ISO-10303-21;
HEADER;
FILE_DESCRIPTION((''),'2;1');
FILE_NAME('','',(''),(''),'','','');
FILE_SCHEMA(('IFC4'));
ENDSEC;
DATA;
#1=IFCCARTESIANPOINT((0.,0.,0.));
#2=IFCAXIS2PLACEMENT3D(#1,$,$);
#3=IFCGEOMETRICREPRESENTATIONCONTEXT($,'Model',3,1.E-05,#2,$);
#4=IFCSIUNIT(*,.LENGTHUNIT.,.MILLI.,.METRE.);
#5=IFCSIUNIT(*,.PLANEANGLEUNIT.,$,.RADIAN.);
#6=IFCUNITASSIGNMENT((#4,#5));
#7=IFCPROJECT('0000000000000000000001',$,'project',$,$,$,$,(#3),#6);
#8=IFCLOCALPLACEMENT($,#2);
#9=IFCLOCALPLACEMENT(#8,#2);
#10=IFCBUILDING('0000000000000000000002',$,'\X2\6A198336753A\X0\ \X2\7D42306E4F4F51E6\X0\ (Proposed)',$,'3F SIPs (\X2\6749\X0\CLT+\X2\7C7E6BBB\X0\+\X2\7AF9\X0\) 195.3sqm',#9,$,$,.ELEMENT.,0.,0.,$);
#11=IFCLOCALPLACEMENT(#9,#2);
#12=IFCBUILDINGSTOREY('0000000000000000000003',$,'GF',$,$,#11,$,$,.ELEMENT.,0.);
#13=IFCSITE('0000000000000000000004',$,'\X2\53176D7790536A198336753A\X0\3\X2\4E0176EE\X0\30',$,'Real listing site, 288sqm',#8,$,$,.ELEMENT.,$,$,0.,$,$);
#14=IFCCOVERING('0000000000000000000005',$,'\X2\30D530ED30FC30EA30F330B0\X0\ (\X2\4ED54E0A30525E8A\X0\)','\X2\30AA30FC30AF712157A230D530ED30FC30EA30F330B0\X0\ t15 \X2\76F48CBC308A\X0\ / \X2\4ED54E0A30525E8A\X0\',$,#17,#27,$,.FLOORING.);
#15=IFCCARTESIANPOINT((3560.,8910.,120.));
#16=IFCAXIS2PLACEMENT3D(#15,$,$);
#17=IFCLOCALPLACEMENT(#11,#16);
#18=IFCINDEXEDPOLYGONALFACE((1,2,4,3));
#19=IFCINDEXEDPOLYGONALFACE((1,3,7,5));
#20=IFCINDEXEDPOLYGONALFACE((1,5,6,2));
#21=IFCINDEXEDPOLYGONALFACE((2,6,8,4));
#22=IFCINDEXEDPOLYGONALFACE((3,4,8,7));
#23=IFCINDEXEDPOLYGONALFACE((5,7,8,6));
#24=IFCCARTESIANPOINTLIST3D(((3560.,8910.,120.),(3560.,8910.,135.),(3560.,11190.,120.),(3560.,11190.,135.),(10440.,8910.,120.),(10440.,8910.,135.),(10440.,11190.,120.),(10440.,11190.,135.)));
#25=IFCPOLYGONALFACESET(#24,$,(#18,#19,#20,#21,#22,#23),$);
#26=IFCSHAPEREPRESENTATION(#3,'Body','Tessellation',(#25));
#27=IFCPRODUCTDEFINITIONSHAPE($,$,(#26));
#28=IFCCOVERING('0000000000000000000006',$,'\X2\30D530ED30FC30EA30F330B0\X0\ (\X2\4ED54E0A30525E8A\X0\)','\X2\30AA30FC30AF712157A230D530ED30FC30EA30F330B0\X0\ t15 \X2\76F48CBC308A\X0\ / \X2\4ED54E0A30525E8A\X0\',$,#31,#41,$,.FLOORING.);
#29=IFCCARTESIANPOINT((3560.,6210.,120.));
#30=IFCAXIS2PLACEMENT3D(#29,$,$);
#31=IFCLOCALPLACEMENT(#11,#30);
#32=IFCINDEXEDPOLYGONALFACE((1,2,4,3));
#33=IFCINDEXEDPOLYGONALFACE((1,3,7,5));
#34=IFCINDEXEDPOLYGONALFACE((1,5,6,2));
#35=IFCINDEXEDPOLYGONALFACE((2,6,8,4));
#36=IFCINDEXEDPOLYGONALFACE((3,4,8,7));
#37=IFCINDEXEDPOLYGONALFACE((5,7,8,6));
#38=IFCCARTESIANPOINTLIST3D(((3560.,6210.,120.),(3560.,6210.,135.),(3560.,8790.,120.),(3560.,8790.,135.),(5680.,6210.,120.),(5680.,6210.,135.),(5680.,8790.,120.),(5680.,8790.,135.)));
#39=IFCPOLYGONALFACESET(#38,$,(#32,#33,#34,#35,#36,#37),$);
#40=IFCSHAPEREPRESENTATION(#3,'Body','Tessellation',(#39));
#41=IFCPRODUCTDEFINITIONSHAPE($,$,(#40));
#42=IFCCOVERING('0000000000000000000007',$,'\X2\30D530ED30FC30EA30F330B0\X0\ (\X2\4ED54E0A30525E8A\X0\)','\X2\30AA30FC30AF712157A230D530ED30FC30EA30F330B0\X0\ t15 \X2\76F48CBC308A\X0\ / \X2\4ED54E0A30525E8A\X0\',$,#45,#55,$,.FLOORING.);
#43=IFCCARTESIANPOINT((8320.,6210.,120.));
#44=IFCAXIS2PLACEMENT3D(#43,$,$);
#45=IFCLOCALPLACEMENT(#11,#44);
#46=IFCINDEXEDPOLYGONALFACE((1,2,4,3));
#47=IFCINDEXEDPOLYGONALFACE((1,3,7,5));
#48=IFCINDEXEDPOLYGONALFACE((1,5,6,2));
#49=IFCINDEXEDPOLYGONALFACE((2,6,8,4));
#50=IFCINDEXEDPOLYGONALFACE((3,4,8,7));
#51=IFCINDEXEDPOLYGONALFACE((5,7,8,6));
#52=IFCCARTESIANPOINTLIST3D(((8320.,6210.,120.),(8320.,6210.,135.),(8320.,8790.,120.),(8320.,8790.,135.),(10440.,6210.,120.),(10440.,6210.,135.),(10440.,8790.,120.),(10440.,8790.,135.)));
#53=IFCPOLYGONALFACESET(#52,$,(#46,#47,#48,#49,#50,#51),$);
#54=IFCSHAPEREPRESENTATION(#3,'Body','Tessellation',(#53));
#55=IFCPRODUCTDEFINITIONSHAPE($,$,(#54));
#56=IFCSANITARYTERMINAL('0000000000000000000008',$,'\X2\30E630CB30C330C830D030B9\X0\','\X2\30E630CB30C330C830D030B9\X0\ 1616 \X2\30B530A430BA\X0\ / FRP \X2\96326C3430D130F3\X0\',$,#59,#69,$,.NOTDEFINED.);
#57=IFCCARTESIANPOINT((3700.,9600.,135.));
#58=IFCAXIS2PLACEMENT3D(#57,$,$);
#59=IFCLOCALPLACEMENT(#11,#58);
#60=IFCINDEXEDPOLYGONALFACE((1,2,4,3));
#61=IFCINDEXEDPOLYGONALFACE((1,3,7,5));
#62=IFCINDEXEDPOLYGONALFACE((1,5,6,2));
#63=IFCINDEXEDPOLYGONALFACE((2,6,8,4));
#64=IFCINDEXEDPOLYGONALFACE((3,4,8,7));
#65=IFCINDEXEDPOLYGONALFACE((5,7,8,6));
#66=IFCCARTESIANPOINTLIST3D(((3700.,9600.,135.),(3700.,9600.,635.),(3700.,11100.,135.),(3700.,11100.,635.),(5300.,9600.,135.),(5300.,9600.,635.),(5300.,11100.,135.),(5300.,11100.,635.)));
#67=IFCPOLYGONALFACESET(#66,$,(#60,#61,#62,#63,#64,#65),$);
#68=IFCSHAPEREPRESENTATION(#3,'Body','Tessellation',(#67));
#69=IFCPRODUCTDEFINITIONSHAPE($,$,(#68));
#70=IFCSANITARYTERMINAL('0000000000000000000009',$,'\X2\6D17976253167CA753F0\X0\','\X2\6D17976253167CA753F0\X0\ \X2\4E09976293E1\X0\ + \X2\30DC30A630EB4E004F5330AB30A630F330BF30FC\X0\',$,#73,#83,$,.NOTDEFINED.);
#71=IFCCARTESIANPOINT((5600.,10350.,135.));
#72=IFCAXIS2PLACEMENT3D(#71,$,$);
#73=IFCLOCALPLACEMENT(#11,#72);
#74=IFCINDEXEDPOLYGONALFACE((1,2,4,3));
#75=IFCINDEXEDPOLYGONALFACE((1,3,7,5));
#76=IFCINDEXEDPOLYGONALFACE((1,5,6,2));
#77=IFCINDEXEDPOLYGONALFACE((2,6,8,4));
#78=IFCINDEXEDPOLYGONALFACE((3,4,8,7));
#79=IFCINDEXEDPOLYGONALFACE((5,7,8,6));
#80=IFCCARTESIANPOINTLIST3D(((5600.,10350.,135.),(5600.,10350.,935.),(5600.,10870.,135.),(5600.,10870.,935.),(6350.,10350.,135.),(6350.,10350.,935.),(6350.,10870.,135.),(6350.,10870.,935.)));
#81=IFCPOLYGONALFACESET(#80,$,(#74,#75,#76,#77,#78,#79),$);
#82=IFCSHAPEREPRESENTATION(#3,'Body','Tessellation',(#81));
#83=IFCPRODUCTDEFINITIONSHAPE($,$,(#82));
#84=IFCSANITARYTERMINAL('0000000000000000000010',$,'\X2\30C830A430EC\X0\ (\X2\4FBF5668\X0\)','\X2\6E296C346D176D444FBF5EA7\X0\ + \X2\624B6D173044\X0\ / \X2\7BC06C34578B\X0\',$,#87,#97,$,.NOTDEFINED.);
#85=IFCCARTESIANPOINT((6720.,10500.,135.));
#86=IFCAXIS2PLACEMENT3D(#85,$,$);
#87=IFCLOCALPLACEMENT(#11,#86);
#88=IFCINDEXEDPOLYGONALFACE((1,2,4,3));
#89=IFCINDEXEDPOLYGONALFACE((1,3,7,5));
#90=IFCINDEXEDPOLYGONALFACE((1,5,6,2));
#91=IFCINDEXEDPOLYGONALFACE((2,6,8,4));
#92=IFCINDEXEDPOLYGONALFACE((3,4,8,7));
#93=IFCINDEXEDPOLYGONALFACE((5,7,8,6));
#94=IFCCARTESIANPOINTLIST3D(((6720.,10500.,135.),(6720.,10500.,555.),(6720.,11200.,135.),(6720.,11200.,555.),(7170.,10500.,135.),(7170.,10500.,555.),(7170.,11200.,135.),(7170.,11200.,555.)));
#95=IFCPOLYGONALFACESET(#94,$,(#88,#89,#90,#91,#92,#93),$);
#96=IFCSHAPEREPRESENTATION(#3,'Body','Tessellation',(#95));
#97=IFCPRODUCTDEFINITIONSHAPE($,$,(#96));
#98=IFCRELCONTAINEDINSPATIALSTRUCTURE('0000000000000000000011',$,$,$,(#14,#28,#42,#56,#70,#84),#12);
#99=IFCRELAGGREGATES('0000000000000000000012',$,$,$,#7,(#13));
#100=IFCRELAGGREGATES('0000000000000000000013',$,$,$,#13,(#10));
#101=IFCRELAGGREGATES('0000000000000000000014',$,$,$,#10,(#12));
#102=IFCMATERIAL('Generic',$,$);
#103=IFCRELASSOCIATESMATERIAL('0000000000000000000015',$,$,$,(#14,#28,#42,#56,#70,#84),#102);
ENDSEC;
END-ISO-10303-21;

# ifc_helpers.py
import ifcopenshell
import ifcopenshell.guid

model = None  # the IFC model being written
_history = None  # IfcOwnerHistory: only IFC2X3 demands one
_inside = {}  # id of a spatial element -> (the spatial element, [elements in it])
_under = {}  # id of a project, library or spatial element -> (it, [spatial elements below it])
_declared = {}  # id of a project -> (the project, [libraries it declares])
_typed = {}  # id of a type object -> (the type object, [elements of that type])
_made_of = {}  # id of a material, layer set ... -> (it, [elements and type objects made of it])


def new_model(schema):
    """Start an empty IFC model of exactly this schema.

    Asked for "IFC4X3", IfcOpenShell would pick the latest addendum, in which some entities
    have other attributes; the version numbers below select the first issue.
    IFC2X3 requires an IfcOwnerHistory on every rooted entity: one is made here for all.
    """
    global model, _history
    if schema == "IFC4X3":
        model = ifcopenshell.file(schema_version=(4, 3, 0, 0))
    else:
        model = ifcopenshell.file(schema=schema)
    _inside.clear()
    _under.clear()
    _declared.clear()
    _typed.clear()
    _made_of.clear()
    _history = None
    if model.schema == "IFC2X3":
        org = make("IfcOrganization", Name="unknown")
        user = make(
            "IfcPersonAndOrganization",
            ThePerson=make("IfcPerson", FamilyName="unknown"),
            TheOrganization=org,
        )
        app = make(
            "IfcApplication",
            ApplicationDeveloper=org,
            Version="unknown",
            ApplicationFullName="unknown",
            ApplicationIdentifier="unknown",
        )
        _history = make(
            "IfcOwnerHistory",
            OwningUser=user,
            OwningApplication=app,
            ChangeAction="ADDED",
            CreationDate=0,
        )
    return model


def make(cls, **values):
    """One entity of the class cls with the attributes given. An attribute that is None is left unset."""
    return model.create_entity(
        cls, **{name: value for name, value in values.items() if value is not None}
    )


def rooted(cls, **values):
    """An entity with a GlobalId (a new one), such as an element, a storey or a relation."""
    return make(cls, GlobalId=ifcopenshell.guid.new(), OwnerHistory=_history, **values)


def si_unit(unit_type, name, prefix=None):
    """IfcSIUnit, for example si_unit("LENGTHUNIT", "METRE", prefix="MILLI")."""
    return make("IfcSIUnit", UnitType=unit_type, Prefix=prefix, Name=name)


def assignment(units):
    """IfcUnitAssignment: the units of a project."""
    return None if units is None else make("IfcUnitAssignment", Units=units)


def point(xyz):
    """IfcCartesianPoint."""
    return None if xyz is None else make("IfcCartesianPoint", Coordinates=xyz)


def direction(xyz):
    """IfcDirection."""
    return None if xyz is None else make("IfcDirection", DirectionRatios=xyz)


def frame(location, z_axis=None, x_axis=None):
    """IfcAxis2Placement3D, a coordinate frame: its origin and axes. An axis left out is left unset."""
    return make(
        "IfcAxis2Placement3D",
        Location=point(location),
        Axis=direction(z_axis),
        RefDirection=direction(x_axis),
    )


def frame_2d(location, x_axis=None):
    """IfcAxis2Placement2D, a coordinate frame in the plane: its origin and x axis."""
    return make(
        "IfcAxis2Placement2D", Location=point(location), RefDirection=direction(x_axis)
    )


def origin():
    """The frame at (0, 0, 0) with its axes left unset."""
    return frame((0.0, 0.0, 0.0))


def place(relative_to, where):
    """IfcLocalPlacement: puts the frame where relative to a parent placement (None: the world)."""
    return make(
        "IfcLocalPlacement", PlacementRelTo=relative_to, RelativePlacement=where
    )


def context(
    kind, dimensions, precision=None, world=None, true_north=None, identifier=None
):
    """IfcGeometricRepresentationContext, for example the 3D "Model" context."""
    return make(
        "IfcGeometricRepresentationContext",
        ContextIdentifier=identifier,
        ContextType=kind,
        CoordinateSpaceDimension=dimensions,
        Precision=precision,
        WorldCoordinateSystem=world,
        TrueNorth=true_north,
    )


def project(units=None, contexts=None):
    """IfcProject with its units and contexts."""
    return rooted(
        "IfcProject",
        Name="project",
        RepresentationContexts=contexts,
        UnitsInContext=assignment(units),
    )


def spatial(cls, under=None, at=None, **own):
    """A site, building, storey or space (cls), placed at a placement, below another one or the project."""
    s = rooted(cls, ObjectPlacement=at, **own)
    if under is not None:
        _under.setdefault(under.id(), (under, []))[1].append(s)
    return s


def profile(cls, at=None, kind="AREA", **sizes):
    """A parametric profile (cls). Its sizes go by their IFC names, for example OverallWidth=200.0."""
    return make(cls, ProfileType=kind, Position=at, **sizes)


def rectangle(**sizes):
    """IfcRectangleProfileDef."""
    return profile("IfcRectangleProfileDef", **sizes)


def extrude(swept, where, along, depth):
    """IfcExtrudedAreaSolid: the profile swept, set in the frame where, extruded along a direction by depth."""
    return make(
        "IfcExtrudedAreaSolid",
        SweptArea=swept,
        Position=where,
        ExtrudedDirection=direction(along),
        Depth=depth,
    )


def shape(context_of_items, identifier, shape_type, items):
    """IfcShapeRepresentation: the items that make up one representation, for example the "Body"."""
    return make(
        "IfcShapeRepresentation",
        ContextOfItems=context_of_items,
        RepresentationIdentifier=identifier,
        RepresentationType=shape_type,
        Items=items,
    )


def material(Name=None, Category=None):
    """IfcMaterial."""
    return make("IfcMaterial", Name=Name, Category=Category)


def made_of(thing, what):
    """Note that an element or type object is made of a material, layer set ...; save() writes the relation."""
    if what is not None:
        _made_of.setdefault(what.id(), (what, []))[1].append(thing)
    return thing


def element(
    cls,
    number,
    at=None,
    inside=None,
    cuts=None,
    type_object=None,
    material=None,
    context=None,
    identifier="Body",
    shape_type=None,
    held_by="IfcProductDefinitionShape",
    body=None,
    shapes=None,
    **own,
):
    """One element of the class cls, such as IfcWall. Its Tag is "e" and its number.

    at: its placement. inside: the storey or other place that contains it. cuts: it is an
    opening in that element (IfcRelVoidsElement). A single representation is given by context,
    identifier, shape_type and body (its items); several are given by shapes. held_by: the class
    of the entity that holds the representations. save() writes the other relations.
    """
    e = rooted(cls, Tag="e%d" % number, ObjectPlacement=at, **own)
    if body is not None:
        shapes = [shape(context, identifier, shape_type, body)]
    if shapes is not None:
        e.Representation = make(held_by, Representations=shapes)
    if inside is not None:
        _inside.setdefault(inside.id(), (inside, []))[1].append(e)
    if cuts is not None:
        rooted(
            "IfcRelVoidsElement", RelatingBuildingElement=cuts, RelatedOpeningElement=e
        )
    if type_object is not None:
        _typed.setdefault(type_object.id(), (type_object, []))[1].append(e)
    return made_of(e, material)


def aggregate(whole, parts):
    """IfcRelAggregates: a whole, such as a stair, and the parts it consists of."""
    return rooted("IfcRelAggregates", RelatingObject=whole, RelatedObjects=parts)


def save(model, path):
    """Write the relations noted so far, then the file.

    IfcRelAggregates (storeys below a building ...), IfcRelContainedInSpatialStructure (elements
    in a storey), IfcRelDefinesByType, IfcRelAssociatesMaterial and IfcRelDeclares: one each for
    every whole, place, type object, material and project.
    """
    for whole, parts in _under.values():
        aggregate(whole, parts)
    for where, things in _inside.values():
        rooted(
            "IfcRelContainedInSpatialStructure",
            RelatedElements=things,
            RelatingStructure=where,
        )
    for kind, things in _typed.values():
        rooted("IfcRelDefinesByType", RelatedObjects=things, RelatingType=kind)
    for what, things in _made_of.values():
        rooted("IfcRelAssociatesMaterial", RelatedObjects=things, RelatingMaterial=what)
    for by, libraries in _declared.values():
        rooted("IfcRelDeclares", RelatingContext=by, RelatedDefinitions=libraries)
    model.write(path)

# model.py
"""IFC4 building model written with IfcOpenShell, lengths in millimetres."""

from ifc_helpers import new_model, si_unit, frame, frame_2d, origin, place, context, project, spatial, rectangle, extrude, material, element, save


model = new_model("IFC4")

# Units and contexts
model_context = context("Model", 3, precision=1e-05, world=origin())
ifc_project = project(units=[si_unit("LENGTHUNIT", "METRE", prefix="MILLI"), si_unit("PLANEANGLEUNIT", "RADIAN")], contexts=[model_context])

# Site, building, storey
site_placement = place(None, origin())
site = spatial("IfcSite", under=ifc_project, at=site_placement, Name="北海道標茶町3丁目30", ObjectType="Real listing site, 288sqm", CompositionType="ELEMENT", RefElevation=0.0)
building_placement = place(site_placement, origin())
building = spatial("IfcBuilding", under=site, at=building_placement, Name="標茶町 終の住処 (Proposed)", ObjectType="3F SIPs (杉CLT+籾殻+竹) 195.3sqm", CompositionType="ELEMENT", ElevationOfRefHeight=0.0, ElevationOfTerrain=0.0)
storey_placement = place(building_placement, origin())
storey = spatial("IfcBuildingStorey", under=building, at=storey_placement, Name="GF", CompositionType="ELEMENT", Elevation=0.0)

# Coverings
ifc_material_1 = material(Name="Generic")
covering_1_placement = place(storey_placement, frame((3560.0, 8910.0, 120.0)))
element("IfcCovering", 1, at=covering_1_placement, inside=storey, material=ifc_material_1, Name="フローリング (仕上げ床)", Description="オーク無垢フローリング t15 直貼り / 仕上げ床", PredefinedType="FLOORING", context=model_context, shape_type="SweptSolid", body=[
    extrude(rectangle(XDim=6880.0, YDim=2280.0, at=frame_2d((3440.0, 1140.0))), frame((3560.0, 8910.0, 120.0)), (0.0, 0.0, 1.0), 15.0),
])
covering_2_placement = place(storey_placement, frame((3560.0, 6210.0, 120.0)))
element("IfcCovering", 2, at=covering_2_placement, inside=storey, material=ifc_material_1, Name="フローリング (仕上げ床)", Description="オーク無垢フローリング t15 直貼り / 仕上げ床", PredefinedType="FLOORING", context=model_context, shape_type="SweptSolid", body=[
    extrude(rectangle(XDim=2120.0, YDim=2580.0, at=frame_2d((1060.0, 1290.0))), frame((3560.0, 6210.0, 120.0)), (0.0, 0.0, 1.0), 15.0),
])
covering_3_placement = place(storey_placement, frame((8320.0, 6210.0, 120.0)))
element("IfcCovering", 3, at=covering_3_placement, inside=storey, material=ifc_material_1, Name="フローリング (仕上げ床)", Description="オーク無垢フローリング t15 直貼り / 仕上げ床", PredefinedType="FLOORING", context=model_context, shape_type="SweptSolid", body=[
    extrude(rectangle(XDim=2120.0, YDim=2580.0, at=frame_2d((1060.0, 1290.0))), frame((8320.0, 6210.0, 120.0)), (0.0, 0.0, 1.0), 15.0),
])

# Sanitary terminals
sanitary_terminal_1_placement = place(storey_placement, frame((3700.0, 9600.0, 135.0)))
element("IfcSanitaryTerminal", 4, at=sanitary_terminal_1_placement, inside=storey, material=ifc_material_1, Name="ユニットバス", Description="ユニットバス 1616 サイズ / FRP 防水パン", PredefinedType="NOTDEFINED", context=model_context, shape_type="SweptSolid", body=[
    extrude(rectangle(XDim=1600.0, YDim=1500.0, at=frame_2d((800.0, 750.0))), frame((3700.0, 9600.0, 135.0)), (0.0, 0.0, 1.0), 500.0),
])
sanitary_terminal_2_placement = place(storey_placement, frame((5600.0, 10350.0, 135.0)))
element("IfcSanitaryTerminal", 5, at=sanitary_terminal_2_placement, inside=storey, material=ifc_material_1, Name="洗面化粧台", Description="洗面化粧台 三面鏡 + ボウル一体カウンター", PredefinedType="NOTDEFINED", context=model_context, shape_type="SweptSolid", body=[
    extrude(rectangle(XDim=750.0, YDim=520.0, at=frame_2d((375.0, 260.0))), frame((5600.0, 10350.0, 135.0)), (0.0, 0.0, 1.0), 800.0),
])
sanitary_terminal_3_placement = place(storey_placement, frame((6720.0, 10500.0, 135.0)))
element("IfcSanitaryTerminal", 6, at=sanitary_terminal_3_placement, inside=storey, material=ifc_material_1, Name="トイレ (便器)", Description="温水洗浄便座 + 手洗い / 節水型", PredefinedType="NOTDEFINED", context=model_context, shape_type="SweptSolid", body=[
    extrude(rectangle(XDim=450.0, YDim=700.0, at=frame_2d((225.0, 350.0))), frame((6720.0, 10500.0, 135.0)), (0.0, 0.0, 1.0), 420.0),
])

save(model, "model.ifc")
